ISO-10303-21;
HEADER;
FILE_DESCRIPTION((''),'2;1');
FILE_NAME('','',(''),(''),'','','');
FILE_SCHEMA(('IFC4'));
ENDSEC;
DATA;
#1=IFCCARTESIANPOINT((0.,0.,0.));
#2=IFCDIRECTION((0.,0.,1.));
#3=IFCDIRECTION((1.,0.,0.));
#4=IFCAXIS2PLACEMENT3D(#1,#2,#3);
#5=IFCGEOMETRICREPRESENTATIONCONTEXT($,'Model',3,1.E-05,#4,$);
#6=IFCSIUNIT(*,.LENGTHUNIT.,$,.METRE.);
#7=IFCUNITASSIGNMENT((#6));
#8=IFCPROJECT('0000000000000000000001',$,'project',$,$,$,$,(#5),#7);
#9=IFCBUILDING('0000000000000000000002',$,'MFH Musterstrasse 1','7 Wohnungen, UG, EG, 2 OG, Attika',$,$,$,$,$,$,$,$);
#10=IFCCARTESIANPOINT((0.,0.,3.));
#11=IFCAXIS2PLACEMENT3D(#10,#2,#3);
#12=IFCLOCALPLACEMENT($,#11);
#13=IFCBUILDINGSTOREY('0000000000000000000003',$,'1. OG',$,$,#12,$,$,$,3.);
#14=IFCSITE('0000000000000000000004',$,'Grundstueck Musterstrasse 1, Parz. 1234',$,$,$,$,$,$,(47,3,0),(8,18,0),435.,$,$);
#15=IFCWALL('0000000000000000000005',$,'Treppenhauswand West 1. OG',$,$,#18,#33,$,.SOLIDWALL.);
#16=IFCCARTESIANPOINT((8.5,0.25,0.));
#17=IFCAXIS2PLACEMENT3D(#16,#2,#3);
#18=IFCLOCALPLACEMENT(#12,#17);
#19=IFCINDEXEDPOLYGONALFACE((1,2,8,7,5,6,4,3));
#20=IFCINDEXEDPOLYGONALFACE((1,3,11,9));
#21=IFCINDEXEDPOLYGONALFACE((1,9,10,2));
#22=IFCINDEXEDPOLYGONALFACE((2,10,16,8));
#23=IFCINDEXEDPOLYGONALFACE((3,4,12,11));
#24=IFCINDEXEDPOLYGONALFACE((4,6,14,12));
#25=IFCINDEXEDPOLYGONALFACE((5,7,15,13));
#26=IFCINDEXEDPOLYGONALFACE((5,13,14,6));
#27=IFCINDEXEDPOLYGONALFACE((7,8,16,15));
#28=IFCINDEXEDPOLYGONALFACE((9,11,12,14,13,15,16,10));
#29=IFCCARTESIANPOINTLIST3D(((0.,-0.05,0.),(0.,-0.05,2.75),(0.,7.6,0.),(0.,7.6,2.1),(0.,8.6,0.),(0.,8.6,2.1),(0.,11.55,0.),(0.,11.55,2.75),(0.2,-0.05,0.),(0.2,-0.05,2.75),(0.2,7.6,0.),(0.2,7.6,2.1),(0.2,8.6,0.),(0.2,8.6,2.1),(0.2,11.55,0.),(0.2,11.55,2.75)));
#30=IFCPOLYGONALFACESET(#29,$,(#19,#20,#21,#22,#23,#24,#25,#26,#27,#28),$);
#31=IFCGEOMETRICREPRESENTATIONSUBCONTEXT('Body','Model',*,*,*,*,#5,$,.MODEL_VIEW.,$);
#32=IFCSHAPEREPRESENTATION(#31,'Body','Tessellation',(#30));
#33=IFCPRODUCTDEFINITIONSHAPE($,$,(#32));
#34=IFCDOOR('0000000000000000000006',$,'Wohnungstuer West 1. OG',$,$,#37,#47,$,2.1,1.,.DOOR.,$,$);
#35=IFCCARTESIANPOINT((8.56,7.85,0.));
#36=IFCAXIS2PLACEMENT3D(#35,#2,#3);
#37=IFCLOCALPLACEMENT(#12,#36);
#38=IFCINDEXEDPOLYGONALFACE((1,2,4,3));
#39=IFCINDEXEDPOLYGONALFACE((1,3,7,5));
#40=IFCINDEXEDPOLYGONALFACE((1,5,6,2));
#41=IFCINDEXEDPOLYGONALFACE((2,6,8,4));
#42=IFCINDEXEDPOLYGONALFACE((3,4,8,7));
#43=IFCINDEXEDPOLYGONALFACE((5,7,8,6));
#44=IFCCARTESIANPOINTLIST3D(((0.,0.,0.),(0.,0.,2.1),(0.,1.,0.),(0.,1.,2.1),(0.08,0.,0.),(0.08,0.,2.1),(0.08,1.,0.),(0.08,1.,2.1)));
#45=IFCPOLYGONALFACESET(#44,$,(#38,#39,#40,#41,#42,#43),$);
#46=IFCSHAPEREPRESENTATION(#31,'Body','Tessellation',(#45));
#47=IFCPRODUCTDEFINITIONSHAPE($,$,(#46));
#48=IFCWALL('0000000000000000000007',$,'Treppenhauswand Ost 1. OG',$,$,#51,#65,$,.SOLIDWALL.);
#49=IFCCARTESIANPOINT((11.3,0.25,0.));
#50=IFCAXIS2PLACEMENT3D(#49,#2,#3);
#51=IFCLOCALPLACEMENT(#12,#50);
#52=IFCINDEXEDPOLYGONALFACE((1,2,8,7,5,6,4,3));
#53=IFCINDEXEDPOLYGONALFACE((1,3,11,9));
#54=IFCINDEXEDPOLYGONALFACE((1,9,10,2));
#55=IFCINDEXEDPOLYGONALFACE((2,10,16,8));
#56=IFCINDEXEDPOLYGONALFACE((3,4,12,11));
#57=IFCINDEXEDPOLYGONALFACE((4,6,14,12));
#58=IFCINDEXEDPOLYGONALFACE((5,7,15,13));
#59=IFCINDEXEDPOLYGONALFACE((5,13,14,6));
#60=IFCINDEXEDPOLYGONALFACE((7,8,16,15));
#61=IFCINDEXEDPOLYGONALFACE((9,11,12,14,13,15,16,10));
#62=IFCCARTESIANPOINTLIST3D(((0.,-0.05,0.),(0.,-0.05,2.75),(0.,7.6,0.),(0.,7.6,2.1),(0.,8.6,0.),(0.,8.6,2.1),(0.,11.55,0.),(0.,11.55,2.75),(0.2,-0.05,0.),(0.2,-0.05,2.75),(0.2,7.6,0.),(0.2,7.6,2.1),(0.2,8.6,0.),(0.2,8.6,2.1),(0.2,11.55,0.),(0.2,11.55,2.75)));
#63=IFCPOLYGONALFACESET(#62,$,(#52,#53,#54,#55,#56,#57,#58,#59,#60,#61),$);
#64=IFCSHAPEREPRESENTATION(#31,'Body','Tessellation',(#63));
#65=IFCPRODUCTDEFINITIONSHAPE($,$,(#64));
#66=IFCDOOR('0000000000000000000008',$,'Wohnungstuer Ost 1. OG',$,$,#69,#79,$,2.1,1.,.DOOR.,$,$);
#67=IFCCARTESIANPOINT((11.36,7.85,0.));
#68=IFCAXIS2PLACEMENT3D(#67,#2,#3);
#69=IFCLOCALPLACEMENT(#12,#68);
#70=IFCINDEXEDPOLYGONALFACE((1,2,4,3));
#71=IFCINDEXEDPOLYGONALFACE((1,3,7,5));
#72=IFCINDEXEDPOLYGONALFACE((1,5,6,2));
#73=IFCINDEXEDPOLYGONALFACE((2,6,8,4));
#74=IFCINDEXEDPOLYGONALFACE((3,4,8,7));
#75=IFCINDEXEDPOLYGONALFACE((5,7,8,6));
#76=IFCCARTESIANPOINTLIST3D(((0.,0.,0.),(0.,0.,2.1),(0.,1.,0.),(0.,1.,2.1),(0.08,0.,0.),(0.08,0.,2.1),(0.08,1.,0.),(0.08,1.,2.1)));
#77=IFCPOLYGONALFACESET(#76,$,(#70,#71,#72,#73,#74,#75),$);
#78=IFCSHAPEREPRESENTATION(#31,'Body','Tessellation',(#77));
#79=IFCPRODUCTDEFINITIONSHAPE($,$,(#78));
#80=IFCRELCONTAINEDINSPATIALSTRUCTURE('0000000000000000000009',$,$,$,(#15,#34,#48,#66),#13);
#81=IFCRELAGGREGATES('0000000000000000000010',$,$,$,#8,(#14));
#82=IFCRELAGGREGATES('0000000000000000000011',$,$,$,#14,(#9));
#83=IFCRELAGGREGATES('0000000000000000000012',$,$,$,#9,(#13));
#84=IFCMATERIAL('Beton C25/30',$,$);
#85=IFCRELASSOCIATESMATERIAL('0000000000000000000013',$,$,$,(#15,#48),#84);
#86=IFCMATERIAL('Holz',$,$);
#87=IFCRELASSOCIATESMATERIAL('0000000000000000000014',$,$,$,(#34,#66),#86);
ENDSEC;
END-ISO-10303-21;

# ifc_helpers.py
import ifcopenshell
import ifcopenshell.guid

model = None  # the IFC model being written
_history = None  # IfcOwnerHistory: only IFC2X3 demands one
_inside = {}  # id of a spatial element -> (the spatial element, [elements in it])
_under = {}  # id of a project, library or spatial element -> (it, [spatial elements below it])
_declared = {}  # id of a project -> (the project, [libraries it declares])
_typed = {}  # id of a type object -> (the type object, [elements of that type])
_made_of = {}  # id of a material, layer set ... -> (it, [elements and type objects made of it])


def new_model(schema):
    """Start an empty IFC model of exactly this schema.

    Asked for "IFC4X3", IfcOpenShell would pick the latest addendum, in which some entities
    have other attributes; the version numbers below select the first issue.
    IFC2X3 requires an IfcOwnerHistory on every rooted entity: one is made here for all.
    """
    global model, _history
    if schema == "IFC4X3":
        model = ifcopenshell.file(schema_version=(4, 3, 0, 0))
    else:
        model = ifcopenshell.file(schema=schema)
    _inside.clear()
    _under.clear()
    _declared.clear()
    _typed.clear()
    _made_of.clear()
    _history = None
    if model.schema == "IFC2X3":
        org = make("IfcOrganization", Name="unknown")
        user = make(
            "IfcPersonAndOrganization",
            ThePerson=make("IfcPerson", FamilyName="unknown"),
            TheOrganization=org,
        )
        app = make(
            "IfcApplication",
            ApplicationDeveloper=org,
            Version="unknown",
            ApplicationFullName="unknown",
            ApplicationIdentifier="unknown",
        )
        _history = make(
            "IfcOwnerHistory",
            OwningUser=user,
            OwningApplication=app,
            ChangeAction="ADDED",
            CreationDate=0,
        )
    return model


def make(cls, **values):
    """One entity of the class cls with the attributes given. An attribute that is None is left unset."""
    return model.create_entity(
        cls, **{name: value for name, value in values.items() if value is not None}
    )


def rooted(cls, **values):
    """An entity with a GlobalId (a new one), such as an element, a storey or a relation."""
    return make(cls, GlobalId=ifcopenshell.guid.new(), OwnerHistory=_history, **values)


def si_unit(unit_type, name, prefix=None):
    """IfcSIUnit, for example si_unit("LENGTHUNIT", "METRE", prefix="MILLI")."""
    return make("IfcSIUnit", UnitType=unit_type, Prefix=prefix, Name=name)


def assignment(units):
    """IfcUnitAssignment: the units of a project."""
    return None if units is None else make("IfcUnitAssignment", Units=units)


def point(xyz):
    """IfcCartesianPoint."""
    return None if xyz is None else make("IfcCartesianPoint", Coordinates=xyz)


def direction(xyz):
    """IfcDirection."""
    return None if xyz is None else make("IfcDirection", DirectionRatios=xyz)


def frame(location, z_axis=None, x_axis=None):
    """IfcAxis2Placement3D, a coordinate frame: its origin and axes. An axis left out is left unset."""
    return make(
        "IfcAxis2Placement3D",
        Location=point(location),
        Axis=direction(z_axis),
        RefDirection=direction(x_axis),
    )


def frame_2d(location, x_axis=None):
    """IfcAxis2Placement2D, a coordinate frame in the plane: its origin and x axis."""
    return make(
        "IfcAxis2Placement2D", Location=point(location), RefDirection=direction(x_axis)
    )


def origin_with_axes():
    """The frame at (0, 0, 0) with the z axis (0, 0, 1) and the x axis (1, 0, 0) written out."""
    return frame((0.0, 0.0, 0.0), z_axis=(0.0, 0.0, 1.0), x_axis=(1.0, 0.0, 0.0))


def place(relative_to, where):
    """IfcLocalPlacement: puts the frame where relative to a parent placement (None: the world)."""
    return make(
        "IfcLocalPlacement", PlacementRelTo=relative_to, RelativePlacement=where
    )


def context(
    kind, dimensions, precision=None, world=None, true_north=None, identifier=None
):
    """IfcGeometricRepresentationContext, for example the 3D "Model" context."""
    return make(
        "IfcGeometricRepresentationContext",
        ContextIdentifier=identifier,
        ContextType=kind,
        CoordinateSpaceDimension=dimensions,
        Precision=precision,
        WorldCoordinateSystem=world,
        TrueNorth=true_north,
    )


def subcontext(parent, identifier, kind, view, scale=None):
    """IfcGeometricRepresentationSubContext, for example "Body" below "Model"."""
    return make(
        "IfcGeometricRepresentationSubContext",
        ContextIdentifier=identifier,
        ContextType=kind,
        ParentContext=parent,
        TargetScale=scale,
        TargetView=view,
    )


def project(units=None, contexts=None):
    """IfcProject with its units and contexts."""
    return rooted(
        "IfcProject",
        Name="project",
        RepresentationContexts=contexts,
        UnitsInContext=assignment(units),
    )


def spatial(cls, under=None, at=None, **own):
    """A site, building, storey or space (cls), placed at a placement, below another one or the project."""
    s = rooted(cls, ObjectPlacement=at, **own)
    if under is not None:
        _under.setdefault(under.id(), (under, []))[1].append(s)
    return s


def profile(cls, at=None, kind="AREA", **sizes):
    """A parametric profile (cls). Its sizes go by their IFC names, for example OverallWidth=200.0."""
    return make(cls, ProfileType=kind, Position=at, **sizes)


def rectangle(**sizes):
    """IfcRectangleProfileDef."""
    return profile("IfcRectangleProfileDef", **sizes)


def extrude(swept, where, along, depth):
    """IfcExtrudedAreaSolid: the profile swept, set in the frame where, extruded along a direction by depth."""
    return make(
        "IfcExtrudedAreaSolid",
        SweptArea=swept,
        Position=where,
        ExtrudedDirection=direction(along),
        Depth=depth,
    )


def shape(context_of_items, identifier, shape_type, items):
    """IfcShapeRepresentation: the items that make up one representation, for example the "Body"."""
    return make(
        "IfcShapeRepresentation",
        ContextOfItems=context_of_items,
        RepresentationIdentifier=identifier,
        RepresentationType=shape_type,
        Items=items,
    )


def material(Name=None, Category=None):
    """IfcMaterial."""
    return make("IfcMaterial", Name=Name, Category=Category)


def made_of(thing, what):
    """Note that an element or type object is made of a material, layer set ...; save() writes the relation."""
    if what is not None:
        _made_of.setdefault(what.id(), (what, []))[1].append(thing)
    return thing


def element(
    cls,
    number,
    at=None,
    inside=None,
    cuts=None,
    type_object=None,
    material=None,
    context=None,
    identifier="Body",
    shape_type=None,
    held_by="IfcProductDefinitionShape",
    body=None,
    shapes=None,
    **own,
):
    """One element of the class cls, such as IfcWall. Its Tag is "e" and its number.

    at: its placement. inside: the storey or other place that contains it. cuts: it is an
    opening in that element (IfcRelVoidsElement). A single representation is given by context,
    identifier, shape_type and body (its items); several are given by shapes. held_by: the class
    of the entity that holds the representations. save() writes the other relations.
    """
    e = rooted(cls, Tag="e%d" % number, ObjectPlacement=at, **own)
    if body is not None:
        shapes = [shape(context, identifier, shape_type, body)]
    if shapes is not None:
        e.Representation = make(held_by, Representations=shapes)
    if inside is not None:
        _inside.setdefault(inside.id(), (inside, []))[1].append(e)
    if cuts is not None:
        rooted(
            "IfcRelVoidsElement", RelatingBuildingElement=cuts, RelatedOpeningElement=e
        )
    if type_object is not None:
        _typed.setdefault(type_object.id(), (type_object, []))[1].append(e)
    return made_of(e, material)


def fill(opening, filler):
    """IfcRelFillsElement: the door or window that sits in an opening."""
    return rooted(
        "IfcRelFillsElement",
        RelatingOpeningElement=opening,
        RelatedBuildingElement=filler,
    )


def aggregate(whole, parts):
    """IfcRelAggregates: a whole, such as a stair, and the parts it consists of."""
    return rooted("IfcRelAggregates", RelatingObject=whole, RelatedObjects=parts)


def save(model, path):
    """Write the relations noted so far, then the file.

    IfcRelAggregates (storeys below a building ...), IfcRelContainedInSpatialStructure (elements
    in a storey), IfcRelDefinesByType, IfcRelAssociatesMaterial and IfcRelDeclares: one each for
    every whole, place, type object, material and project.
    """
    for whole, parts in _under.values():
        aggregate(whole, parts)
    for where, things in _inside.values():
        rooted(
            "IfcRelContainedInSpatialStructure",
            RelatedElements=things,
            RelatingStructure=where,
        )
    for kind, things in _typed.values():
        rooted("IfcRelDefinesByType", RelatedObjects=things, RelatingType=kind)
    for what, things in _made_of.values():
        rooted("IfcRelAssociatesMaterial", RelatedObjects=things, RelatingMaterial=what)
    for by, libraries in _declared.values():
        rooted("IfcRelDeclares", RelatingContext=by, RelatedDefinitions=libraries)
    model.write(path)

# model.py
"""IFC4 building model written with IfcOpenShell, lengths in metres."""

from ifc_helpers import new_model, si_unit, frame, frame_2d, origin_with_axes, place, context, subcontext, project, spatial, rectangle, extrude, material, element, fill, save


model = new_model("IFC4")

# Units and contexts
model_context = context("Model", 3, precision=1e-05, world=origin_with_axes())
body_context = subcontext(model_context, "Body", "Model", "MODEL_VIEW")
ifc_project = project(units=[si_unit("LENGTHUNIT", "METRE")], contexts=[model_context])

# Site, building, storey
site = spatial("IfcSite", under=ifc_project, Name="Grundstueck Musterstrasse 1, Parz. 1234", RefLatitude=(47, 3, 0), RefLongitude=(8, 18, 0), RefElevation=435.0)
building = spatial("IfcBuilding", under=site, Name="MFH Musterstrasse 1", Description="7 Wohnungen, UG, EG, 2 OG, Attika")
storey_placement = place(None, frame((0.0, 0.0, 3.0), z_axis=(0.0, 0.0, 1.0), x_axis=(1.0, 0.0, 0.0)))
storey = spatial("IfcBuildingStorey", under=building, at=storey_placement, Name="1. OG", Elevation=3.0)

# Walls, openings, doors
ifc_material_1 = material(Name="Beton C25/30")
wall_1_placement = place(storey_placement, frame((8.5, 0.25, 0.0), z_axis=(0.0, 0.0, 1.0), x_axis=(1.0, 0.0, 0.0)))
wall_1 = element("IfcWall", 1, at=wall_1_placement, inside=storey, material=ifc_material_1, Name="Treppenhauswand West 1. OG", PredefinedType="SOLIDWALL", context=body_context, shape_type="SweptSolid", body=[
    extrude(rectangle(XDim=0.2, YDim=11.6, at=frame_2d((0.1, 5.75))), origin_with_axes(), (0.0, 0.0, 1.0), 2.75),
])
opening_1_placement = place(wall_1_placement, frame((-0.01, 7.6, 0.0), z_axis=(0.0, 0.0, 1.0), x_axis=(1.0, 0.0, 0.0)))
opening_1 = element("IfcOpeningElement", 2, at=opening_1_placement, cuts=wall_1, context=body_context, shape_type="SweptSolid", body=[
    extrude(rectangle(XDim=0.22, YDim=1.0, at=frame_2d((0.11, 0.5))), origin_with_axes(), (0.0, 0.0, 1.0), 2.1),
])
ifc_material_2 = material(Name="Holz")
door_1_placement = place(storey_placement, frame((8.56, 7.85, 0.0), z_axis=(0.0, 0.0, 1.0), x_axis=(1.0, 0.0, 0.0)))
door_1 = element("IfcDoor", 3, at=door_1_placement, inside=storey, material=ifc_material_2, Name="Wohnungstuer West 1. OG", OverallHeight=2.1, OverallWidth=1.0, PredefinedType="DOOR", context=body_context, shape_type="SweptSolid", body=[
    extrude(rectangle(XDim=0.08, YDim=1.0, at=frame_2d((0.04, 0.5))), origin_with_axes(), (0.0, 0.0, 1.0), 2.1),
])
fill(opening_1, door_1)
wall_2_placement = place(storey_placement, frame((11.3, 0.25, 0.0), z_axis=(0.0, 0.0, 1.0), x_axis=(1.0, 0.0, 0.0)))
wall_2 = element("IfcWall", 4, at=wall_2_placement, inside=storey, material=ifc_material_1, Name="Treppenhauswand Ost 1. OG", PredefinedType="SOLIDWALL", context=body_context, shape_type="SweptSolid", body=[
    extrude(rectangle(XDim=0.2, YDim=11.6, at=frame_2d((0.1, 5.75))), origin_with_axes(), (0.0, 0.0, 1.0), 2.75),
])
opening_2_placement = place(wall_2_placement, frame((-0.01, 7.6, 0.0), z_axis=(0.0, 0.0, 1.0), x_axis=(1.0, 0.0, 0.0)))
opening_2 = element("IfcOpeningElement", 5, at=opening_2_placement, cuts=wall_2, context=body_context, shape_type="SweptSolid", body=[
    extrude(rectangle(XDim=0.22, YDim=1.0, at=frame_2d((0.11, 0.5))), origin_with_axes(), (0.0, 0.0, 1.0), 2.1),
])
door_2_placement = place(storey_placement, frame((11.36, 7.85, 0.0), z_axis=(0.0, 0.0, 1.0), x_axis=(1.0, 0.0, 0.0)))
door_2 = element("IfcDoor", 6, at=door_2_placement, inside=storey, material=ifc_material_2, Name="Wohnungstuer Ost 1. OG", OverallHeight=2.1, OverallWidth=1.0, PredefinedType="DOOR", context=body_context, shape_type="SweptSolid", body=[
    extrude(rectangle(XDim=0.08, YDim=1.0, at=frame_2d((0.04, 0.5))), origin_with_axes(), (0.0, 0.0, 1.0), 2.1),
])
fill(opening_2, door_2)

save(model, "model.ifc")
